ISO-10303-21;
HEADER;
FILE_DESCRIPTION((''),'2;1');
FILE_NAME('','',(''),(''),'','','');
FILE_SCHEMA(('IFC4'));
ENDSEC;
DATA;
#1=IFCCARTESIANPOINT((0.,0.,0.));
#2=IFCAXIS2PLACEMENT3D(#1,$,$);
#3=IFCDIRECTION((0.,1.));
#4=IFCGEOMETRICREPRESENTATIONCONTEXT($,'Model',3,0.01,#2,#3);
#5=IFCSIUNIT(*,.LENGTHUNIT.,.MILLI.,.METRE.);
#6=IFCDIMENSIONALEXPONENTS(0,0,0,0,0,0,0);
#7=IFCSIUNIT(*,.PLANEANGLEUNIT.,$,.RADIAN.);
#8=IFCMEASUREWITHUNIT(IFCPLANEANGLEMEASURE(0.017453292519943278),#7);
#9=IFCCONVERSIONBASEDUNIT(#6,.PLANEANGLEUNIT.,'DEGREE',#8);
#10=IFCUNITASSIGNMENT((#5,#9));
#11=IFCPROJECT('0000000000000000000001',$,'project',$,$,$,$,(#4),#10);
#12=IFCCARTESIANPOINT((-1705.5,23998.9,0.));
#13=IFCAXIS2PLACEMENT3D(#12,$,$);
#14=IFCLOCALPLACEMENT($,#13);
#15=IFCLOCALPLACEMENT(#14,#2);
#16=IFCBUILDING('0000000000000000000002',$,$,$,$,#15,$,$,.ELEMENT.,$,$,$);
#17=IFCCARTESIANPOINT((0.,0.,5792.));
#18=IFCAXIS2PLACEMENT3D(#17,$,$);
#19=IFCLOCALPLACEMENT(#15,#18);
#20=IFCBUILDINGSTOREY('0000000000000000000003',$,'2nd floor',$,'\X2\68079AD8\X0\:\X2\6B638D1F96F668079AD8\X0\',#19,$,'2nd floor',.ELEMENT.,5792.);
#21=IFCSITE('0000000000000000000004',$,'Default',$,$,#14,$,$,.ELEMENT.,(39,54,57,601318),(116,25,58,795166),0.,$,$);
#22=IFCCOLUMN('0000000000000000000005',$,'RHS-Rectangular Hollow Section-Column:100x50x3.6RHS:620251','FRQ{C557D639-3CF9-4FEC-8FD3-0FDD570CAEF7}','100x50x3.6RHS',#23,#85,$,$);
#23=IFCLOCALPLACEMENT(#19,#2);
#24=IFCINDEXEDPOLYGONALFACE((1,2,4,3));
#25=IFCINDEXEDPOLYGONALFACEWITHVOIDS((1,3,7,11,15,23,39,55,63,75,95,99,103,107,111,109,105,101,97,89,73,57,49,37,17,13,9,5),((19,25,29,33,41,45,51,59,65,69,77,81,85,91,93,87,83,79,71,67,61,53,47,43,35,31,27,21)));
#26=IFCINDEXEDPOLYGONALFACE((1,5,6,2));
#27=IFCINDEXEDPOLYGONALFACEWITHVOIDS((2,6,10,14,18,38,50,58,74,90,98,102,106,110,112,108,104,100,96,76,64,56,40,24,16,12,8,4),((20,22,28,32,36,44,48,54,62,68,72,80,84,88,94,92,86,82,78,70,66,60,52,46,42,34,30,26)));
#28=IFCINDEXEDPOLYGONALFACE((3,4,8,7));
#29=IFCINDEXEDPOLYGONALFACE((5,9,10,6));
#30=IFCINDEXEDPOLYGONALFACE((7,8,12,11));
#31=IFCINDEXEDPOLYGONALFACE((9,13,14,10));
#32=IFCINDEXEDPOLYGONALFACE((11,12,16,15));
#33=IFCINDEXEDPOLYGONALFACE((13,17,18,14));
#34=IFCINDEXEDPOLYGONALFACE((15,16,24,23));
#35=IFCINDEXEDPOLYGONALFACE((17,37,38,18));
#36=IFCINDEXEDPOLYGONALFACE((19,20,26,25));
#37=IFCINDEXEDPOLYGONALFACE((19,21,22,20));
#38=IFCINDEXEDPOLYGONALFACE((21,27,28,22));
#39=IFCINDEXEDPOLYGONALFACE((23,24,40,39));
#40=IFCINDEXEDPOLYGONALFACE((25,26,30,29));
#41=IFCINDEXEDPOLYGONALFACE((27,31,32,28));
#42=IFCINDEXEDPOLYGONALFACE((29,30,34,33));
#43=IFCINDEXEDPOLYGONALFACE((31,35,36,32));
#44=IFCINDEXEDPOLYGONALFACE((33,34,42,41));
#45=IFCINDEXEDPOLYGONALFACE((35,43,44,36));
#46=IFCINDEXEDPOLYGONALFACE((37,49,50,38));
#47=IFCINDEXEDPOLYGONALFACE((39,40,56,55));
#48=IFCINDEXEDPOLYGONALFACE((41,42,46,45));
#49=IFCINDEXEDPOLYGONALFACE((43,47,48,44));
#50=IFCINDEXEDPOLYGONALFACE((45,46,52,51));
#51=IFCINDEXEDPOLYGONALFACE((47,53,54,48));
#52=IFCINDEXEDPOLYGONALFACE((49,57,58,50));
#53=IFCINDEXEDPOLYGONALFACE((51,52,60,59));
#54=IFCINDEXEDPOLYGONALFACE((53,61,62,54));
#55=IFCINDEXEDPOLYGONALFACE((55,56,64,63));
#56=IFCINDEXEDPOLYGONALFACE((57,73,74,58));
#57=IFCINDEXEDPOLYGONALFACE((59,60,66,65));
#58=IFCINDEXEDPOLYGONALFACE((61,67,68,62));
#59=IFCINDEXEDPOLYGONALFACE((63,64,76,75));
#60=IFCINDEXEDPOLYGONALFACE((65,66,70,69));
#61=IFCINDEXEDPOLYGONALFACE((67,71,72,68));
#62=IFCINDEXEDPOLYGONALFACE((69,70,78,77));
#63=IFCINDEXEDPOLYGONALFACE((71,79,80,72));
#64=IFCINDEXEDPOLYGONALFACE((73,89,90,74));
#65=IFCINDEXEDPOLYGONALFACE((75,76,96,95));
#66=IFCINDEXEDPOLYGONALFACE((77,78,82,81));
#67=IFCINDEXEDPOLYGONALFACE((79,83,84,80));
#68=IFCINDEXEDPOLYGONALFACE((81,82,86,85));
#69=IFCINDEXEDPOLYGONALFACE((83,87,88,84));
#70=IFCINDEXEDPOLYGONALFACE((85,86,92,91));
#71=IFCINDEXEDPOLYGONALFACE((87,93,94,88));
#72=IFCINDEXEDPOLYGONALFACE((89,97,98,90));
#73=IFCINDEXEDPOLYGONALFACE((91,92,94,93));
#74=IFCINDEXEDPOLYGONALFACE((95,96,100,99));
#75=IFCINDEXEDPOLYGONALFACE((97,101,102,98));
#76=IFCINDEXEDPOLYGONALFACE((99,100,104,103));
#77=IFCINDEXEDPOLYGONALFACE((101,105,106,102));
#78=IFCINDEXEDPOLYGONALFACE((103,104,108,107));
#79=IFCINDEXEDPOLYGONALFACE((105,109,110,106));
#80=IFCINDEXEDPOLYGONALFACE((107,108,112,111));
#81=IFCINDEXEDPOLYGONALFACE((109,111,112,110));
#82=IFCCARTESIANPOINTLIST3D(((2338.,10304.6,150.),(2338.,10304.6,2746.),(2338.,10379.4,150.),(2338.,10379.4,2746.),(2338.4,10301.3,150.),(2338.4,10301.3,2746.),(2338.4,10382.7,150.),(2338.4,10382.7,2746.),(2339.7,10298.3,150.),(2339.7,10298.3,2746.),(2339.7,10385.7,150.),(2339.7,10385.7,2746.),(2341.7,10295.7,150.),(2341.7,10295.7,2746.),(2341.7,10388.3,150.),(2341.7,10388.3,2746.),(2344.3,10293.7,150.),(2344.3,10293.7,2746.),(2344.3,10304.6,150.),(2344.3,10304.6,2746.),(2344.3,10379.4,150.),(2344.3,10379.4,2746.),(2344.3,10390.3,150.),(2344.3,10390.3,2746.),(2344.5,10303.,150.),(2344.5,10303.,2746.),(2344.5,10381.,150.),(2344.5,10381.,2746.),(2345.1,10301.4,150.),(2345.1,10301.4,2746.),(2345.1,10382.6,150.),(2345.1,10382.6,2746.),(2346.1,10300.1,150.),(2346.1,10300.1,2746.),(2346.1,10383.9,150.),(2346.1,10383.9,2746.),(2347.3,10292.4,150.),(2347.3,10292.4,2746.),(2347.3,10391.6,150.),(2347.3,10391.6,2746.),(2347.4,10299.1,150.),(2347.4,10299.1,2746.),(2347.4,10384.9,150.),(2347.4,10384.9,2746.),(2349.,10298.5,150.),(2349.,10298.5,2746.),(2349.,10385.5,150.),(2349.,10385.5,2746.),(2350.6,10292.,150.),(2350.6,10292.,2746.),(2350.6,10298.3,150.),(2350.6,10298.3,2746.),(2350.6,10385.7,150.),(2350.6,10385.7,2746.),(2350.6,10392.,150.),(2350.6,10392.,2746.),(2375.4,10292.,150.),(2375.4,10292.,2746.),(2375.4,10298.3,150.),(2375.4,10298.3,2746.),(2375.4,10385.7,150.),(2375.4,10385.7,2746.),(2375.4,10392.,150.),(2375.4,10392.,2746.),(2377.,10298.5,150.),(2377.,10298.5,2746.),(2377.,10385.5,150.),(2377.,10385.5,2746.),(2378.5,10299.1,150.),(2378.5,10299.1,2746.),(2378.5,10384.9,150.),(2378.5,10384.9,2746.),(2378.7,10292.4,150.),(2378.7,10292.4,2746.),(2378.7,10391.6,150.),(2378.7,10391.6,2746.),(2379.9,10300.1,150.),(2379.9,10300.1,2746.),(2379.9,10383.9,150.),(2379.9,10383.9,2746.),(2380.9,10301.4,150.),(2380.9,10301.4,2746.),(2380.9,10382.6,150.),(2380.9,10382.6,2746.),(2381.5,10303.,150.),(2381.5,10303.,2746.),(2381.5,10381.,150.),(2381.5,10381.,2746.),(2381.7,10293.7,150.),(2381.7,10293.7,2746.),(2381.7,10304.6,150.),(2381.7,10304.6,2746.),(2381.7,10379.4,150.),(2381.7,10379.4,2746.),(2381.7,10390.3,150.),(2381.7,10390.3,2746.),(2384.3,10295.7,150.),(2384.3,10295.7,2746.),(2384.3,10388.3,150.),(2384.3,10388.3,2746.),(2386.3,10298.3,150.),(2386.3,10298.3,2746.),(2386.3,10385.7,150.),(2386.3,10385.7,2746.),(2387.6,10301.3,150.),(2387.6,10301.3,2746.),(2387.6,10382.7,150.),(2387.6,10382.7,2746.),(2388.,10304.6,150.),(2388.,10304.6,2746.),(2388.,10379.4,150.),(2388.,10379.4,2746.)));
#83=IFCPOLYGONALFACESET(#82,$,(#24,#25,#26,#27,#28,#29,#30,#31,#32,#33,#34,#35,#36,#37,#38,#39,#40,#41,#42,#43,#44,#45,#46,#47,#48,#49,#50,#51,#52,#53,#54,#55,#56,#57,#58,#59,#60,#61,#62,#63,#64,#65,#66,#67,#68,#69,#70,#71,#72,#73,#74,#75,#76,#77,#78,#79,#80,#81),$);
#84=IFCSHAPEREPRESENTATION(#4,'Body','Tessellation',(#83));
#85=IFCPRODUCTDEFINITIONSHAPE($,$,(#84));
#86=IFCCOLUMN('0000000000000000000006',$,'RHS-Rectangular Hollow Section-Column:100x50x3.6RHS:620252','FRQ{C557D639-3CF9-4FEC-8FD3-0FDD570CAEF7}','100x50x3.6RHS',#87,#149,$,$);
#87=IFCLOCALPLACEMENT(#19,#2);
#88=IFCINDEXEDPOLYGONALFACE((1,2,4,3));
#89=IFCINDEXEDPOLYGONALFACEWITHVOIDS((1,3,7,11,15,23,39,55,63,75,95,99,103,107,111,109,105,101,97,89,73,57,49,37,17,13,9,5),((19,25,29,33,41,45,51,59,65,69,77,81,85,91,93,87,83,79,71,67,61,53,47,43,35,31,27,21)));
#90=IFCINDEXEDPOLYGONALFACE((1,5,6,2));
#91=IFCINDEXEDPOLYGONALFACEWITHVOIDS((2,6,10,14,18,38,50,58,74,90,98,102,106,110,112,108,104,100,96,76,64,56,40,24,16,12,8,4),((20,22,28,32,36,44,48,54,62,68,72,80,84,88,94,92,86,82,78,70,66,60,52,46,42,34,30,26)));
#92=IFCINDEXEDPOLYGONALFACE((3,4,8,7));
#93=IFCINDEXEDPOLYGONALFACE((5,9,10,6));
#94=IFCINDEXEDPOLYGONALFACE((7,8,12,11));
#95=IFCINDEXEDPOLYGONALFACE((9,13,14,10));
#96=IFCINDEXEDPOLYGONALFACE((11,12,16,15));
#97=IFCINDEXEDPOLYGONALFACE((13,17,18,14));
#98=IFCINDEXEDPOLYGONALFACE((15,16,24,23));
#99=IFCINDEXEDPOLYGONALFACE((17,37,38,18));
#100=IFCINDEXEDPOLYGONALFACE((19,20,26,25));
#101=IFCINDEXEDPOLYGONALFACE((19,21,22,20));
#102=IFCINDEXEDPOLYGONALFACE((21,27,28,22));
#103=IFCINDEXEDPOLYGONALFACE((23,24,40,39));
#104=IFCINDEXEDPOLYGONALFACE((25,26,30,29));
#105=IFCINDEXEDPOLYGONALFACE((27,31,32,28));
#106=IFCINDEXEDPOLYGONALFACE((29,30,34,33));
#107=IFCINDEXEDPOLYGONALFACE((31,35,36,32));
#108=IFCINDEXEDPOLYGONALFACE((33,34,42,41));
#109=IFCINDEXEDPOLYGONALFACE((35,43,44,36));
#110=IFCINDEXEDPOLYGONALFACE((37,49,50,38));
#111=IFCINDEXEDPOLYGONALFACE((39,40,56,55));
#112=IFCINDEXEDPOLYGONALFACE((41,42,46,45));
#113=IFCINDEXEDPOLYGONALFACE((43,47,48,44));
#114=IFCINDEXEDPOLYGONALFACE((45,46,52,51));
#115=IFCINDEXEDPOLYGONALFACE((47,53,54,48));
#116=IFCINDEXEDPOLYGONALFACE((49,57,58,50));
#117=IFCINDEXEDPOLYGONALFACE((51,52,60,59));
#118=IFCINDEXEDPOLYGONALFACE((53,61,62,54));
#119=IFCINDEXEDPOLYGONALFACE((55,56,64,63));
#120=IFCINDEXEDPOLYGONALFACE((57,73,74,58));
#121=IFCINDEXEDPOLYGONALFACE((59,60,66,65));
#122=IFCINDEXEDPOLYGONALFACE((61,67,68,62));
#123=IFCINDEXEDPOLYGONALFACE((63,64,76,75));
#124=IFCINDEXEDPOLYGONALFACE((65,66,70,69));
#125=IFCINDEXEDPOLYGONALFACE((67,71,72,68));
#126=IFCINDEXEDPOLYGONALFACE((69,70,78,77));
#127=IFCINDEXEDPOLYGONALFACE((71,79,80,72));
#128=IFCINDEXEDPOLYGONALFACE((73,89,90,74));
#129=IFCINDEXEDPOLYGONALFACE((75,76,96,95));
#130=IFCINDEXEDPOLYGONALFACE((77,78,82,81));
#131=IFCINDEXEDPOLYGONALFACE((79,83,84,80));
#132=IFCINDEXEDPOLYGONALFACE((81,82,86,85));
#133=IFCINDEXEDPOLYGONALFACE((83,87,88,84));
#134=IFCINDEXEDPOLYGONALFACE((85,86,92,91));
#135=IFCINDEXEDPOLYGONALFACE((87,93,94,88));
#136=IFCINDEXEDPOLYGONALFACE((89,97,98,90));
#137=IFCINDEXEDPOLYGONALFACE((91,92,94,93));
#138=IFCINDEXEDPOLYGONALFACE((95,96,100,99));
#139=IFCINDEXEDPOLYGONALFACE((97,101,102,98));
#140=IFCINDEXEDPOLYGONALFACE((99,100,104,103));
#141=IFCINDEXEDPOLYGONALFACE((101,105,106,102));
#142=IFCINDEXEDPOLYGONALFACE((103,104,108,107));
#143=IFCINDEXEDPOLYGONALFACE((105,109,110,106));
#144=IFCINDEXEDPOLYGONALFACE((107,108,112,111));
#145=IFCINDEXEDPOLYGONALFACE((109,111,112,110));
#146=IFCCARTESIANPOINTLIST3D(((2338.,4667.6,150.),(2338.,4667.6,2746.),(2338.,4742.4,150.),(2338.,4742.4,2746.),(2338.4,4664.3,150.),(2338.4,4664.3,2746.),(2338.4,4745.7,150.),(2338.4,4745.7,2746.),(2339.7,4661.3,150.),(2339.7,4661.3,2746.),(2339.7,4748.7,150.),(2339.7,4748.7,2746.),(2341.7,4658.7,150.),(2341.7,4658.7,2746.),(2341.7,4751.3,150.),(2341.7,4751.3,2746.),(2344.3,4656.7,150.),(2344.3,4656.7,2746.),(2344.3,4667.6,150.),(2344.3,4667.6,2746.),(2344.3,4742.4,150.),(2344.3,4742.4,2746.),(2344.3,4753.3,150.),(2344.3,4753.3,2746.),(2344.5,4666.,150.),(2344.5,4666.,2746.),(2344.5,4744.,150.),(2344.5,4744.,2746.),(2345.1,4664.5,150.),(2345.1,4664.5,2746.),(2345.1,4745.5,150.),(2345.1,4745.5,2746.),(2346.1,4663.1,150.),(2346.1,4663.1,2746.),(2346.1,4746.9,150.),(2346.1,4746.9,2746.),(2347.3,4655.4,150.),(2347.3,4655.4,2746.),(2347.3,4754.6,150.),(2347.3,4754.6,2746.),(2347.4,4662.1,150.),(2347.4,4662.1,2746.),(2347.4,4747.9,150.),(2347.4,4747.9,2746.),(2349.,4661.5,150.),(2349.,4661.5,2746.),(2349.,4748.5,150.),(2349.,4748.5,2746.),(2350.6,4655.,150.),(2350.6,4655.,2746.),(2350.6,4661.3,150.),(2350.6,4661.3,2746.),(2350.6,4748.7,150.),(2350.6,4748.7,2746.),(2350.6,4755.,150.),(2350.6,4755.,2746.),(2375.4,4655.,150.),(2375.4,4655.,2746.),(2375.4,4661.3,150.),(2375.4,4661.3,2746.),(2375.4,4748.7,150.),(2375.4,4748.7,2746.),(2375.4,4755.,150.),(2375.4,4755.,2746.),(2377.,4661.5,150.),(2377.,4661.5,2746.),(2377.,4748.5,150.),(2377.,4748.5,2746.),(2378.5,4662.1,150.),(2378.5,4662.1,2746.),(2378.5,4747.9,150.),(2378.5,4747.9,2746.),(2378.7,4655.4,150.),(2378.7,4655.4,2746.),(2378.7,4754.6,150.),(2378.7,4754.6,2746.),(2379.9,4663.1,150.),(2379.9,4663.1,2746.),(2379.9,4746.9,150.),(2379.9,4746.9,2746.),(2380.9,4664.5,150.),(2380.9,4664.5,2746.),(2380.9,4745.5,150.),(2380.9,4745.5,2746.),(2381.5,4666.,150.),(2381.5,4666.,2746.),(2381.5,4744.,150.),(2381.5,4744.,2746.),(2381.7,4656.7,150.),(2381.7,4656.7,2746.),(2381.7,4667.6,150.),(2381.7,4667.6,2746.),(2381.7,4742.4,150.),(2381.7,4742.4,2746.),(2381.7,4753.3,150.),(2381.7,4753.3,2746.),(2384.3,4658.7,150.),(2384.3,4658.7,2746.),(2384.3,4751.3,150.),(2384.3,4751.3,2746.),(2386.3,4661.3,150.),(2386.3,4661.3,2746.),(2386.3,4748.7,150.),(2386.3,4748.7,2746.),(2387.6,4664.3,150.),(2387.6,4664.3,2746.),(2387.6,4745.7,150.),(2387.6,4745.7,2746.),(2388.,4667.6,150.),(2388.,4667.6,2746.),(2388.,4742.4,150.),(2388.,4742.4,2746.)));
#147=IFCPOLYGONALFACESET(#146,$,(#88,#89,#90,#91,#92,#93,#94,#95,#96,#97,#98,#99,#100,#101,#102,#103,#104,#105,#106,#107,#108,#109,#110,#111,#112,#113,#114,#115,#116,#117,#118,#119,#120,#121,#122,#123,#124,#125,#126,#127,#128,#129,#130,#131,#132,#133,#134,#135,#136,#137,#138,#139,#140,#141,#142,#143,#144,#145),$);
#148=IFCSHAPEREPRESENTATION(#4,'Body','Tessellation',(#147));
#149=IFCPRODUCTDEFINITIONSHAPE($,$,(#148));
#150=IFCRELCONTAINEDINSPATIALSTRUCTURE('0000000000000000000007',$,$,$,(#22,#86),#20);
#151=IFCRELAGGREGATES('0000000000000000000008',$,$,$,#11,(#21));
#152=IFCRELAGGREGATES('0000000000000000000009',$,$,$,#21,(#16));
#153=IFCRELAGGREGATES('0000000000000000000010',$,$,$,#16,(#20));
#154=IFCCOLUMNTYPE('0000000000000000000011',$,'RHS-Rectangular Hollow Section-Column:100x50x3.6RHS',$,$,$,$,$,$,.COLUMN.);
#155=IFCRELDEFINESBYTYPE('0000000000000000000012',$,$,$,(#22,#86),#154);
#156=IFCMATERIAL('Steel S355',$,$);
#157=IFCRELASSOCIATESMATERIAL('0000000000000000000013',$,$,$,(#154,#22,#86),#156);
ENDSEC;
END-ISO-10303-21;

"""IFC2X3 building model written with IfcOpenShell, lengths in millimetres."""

from ifc_helpers import new_model, entity, si_unit, converted_unit, direction, frame, origin, origin_2d, place, context, project, spatial, hollow_rectangle, extrude, clip, halfspace, material, type_object, element, save


model = new_model("IFC2X3")

# Units and contexts
model_context = context("Model", 3, precision=0.01, world=origin(), true_north=direction((0.0, 1.0)))
ifc_project = project(units=[si_unit("LENGTHUNIT", "METRE", prefix="MILLI"), converted_unit("PLANEANGLEUNIT", "DEGREE", entity("IfcPlaneAngleMeasure", 0.017453292519943278), si_unit("PLANEANGLEUNIT", "RADIAN"), dimensions=[0, 0, 0, 0, 0, 0, 0])], contexts=[model_context])

# Site, building, storey
site_placement = place(None, frame((-1705.5, 23998.9, 0.0)))
site = spatial("IfcSite", under=ifc_project, at=site_placement, Name="Default", CompositionType="ELEMENT", RefLatitude=(39, 54, 57, 601318), RefLongitude=(116, 25, 58, 795166), RefElevation=0.0)
building_placement = place(site_placement, origin())
building = spatial("IfcBuilding", under=site, at=building_placement, CompositionType="ELEMENT")
storey_placement = place(building_placement, frame((0.0, 0.0, 5792.0)))
storey = spatial("IfcBuildingStorey", under=building, at=storey_placement, Name="2nd floor", ObjectType="标高:正负零标高", LongName="2nd floor", CompositionType="ELEMENT", Elevation=5792.0)

# Columns
ifc_material_1 = material(Name="Steel S355")
column_type = type_object("IfcColumnType", Name="RHS-Rectangular Hollow Section-Column:100x50x3.6RHS", PredefinedType="COLUMN", material=ifc_material_1)
column_1_placement = place(storey_placement, frame((2363.0, 10342.0, 2746.0), z_axis=(0.0, 0.0, 1.0), x_axis=(-1.0, 0.0, 0.0)))
element("IfcColumn", 1, at=column_1_placement, inside=storey, type_object=column_type, material=ifc_material_1, Name="RHS-Rectangular Hollow Section-Column:100x50x3.6RHS:620251", Description="FRQ{C557D639-3CF9-4FEC-8FD3-0FDD570CAEF7}", ObjectType="100x50x3.6RHS", context=model_context, shape_type="Clipping", body=[
    clip(extrude(hollow_rectangle(XDim=50.0, YDim=100.0, WallThickness=6.3, InnerFilletRadius=6.3, OuterFilletRadius=12.6, at=origin_2d()), origin(), (0.0, 0.0, -1.0), 2651.9), halfspace(frame((2363.0, 10342.0, -2596.0), z_axis=(0.0, 0.0, 1.0), x_axis=(-1.0, 0.0, 0.0)), True)),
])
column_2_placement = place(storey_placement, frame((2363.0, 4705.0, 2746.0), z_axis=(0.0, 0.0, 1.0), x_axis=(-1.0, 0.0, 0.0)))
element("IfcColumn", 2, at=column_2_placement, inside=storey, type_object=column_type, material=ifc_material_1, Name="RHS-Rectangular Hollow Section-Column:100x50x3.6RHS:620252", Description="FRQ{C557D639-3CF9-4FEC-8FD3-0FDD570CAEF7}", ObjectType="100x50x3.6RHS", context=model_context, shape_type="Clipping", body=[
    clip(extrude(hollow_rectangle(XDim=50.0, YDim=100.0, WallThickness=6.3, InnerFilletRadius=6.3, OuterFilletRadius=12.6, at=origin_2d()), origin(), (0.0, 0.0, -1.0), 2651.9), halfspace(frame((2363.0, 4705.0, -2596.0), z_axis=(0.0, 0.0, 1.0), x_axis=(-1.0, 0.0, 0.0)), True)),
])

save(model, "model.ifc")
